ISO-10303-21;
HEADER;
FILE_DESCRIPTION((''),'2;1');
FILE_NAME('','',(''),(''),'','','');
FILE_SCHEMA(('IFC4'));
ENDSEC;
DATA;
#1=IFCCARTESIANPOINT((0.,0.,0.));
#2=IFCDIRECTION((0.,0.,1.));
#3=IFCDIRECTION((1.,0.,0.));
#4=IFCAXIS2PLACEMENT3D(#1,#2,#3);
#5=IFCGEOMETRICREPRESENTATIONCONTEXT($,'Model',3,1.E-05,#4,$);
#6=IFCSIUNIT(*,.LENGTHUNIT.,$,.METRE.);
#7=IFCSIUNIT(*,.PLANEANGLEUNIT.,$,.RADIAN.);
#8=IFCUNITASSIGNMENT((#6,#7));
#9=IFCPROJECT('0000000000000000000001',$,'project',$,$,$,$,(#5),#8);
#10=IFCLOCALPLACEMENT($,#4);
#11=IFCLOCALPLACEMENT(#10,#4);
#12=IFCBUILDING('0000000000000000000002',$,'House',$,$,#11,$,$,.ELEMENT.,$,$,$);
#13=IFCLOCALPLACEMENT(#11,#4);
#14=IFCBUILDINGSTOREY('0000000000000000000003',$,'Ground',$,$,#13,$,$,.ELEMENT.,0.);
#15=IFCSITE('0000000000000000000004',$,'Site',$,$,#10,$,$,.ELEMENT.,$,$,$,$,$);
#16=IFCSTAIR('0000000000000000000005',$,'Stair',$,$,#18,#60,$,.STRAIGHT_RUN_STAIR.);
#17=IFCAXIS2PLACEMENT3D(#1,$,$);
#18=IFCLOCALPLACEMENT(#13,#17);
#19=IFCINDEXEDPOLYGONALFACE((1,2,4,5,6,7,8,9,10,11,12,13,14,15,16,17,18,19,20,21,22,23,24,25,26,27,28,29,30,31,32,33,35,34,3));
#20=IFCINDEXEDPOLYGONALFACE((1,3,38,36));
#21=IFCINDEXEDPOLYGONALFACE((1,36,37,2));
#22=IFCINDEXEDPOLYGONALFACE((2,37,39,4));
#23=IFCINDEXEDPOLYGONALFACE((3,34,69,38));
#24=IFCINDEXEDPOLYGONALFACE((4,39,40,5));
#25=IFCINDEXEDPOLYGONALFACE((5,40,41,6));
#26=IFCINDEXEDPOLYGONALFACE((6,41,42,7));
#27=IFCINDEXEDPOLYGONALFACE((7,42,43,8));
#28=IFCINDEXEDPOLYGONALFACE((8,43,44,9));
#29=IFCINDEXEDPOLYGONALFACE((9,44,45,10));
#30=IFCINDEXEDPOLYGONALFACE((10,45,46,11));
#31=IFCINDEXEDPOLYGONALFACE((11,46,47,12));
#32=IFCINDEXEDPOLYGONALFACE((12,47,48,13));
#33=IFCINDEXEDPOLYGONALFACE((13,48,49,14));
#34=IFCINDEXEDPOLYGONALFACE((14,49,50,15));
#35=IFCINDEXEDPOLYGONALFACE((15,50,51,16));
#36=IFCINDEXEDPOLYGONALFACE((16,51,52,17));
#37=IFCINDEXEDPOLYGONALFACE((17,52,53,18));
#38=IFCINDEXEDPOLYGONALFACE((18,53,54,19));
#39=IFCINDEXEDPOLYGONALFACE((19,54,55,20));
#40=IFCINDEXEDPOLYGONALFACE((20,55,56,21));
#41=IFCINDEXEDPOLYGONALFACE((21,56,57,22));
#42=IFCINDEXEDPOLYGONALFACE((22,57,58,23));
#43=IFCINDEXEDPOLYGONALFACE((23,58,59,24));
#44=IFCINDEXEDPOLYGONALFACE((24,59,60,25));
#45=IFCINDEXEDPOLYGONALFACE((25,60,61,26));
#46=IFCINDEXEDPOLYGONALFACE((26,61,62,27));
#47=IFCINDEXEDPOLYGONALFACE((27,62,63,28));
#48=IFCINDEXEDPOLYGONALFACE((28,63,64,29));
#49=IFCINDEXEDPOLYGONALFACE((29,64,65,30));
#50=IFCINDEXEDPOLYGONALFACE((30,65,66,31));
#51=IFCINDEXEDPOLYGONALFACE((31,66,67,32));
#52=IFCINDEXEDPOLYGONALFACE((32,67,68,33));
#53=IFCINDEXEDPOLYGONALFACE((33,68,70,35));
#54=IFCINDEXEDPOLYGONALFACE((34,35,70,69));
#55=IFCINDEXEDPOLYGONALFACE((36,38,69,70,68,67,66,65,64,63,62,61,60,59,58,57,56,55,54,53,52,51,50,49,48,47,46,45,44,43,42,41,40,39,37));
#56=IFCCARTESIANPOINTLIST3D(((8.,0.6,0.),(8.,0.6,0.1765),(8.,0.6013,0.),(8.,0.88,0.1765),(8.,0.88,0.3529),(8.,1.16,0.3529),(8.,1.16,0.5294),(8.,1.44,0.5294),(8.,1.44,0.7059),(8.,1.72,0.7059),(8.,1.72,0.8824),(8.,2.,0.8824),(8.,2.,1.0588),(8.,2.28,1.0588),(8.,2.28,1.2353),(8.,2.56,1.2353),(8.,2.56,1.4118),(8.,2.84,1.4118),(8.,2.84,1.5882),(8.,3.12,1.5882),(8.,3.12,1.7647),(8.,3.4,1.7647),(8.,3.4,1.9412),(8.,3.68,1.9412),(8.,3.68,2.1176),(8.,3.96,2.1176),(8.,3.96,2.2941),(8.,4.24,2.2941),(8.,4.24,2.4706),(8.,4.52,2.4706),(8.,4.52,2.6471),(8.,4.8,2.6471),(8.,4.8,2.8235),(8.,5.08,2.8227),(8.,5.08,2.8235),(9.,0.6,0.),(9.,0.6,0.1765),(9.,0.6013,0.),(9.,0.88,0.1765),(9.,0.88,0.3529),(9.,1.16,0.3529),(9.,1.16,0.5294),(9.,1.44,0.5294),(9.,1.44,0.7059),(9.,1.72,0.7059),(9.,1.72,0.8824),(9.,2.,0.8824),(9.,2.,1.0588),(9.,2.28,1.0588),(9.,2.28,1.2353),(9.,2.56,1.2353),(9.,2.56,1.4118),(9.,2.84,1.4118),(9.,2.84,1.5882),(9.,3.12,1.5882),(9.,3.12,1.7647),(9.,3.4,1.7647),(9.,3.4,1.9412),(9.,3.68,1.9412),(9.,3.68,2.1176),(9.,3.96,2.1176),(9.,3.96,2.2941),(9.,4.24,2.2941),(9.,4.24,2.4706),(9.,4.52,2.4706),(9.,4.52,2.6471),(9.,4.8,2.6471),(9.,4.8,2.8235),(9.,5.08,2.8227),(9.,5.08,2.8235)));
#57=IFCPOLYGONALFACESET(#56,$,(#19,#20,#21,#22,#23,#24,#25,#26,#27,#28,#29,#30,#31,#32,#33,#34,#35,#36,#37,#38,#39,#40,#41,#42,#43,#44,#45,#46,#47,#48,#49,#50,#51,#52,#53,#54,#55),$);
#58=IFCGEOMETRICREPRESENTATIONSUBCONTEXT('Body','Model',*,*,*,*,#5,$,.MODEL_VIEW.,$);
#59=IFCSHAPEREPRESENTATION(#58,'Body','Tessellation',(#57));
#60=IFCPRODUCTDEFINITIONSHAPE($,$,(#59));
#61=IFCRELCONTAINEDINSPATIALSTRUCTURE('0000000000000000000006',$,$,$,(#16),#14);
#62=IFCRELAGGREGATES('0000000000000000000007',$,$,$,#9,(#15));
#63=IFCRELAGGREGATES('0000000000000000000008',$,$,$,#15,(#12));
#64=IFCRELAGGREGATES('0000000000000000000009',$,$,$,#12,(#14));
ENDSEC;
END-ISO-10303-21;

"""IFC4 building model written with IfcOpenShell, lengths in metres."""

from ifc_helpers import new_model, si_unit, frame, origin_with_axes, place, context, subcontext, project, spatial, polyline, outline, extrude, element, save


model = new_model("IFC4")

# Units and contexts
model_context = context("Model", 3, precision=1e-05, world=origin_with_axes())
body_context = subcontext(model_context, "Body", "Model", "MODEL_VIEW")
ifc_project = project(units=[si_unit("LENGTHUNIT", "METRE"), si_unit("PLANEANGLEUNIT", "RADIAN")], contexts=[model_context])

# Site, building, storey
site_placement = place(None, origin_with_axes())
site = spatial("IfcSite", under=ifc_project, at=site_placement, Name="Site", CompositionType="ELEMENT")
building_placement = place(site_placement, origin_with_axes())
building = spatial("IfcBuilding", under=site, at=building_placement, Name="House", CompositionType="ELEMENT")
storey_placement = place(building_placement, origin_with_axes())
storey = spatial("IfcBuildingStorey", under=building, at=storey_placement, Name="Ground", CompositionType="ELEMENT", Elevation=0.0)

# Stair
stair_placement = place(storey_placement, frame((8.0, 0.6, 0.0), z_axis=(1.0, 0.0, 0.0), x_axis=(0.0, 1.0, 0.0)))
element("IfcStair", 1, at=stair_placement, inside=storey, Name="Stair", PredefinedType="STRAIGHT_RUN_STAIR", context=body_context, shape_type="SweptSolid", body=[
    extrude(outline(polyline([(0.0013, 0.0), (4.48, 2.8227), (4.48, 2.8235), (4.2, 2.8235), (4.2, 2.6471), (3.92, 2.6471), (3.92, 2.4706), (3.64, 2.4706), (3.64, 2.2941), (3.36, 2.2941), (3.36, 2.1176), (3.08, 2.1176), (3.08, 1.9412), (2.8, 1.9412), (2.8, 1.7647), (2.52, 1.7647), (2.52, 1.5882), (2.24, 1.5882), (2.24, 1.4118), (1.96, 1.4118), (1.96, 1.2353), (1.68, 1.2353), (1.68, 1.0588), (1.4, 1.0588), (1.4, 0.8824), (1.12, 0.8824), (1.12, 0.7059), (0.84, 0.7059), (0.84, 0.5294), (0.56, 0.5294), (0.56, 0.3529), (0.28, 0.3529), (0.28, 0.1765), (0.0, 0.1765), (0.0, 0.0), (0.0013, 0.0)])), origin_with_axes(), (0.0, 0.0, 1.0), 1.0),
])

save(model, "model.ifc")
